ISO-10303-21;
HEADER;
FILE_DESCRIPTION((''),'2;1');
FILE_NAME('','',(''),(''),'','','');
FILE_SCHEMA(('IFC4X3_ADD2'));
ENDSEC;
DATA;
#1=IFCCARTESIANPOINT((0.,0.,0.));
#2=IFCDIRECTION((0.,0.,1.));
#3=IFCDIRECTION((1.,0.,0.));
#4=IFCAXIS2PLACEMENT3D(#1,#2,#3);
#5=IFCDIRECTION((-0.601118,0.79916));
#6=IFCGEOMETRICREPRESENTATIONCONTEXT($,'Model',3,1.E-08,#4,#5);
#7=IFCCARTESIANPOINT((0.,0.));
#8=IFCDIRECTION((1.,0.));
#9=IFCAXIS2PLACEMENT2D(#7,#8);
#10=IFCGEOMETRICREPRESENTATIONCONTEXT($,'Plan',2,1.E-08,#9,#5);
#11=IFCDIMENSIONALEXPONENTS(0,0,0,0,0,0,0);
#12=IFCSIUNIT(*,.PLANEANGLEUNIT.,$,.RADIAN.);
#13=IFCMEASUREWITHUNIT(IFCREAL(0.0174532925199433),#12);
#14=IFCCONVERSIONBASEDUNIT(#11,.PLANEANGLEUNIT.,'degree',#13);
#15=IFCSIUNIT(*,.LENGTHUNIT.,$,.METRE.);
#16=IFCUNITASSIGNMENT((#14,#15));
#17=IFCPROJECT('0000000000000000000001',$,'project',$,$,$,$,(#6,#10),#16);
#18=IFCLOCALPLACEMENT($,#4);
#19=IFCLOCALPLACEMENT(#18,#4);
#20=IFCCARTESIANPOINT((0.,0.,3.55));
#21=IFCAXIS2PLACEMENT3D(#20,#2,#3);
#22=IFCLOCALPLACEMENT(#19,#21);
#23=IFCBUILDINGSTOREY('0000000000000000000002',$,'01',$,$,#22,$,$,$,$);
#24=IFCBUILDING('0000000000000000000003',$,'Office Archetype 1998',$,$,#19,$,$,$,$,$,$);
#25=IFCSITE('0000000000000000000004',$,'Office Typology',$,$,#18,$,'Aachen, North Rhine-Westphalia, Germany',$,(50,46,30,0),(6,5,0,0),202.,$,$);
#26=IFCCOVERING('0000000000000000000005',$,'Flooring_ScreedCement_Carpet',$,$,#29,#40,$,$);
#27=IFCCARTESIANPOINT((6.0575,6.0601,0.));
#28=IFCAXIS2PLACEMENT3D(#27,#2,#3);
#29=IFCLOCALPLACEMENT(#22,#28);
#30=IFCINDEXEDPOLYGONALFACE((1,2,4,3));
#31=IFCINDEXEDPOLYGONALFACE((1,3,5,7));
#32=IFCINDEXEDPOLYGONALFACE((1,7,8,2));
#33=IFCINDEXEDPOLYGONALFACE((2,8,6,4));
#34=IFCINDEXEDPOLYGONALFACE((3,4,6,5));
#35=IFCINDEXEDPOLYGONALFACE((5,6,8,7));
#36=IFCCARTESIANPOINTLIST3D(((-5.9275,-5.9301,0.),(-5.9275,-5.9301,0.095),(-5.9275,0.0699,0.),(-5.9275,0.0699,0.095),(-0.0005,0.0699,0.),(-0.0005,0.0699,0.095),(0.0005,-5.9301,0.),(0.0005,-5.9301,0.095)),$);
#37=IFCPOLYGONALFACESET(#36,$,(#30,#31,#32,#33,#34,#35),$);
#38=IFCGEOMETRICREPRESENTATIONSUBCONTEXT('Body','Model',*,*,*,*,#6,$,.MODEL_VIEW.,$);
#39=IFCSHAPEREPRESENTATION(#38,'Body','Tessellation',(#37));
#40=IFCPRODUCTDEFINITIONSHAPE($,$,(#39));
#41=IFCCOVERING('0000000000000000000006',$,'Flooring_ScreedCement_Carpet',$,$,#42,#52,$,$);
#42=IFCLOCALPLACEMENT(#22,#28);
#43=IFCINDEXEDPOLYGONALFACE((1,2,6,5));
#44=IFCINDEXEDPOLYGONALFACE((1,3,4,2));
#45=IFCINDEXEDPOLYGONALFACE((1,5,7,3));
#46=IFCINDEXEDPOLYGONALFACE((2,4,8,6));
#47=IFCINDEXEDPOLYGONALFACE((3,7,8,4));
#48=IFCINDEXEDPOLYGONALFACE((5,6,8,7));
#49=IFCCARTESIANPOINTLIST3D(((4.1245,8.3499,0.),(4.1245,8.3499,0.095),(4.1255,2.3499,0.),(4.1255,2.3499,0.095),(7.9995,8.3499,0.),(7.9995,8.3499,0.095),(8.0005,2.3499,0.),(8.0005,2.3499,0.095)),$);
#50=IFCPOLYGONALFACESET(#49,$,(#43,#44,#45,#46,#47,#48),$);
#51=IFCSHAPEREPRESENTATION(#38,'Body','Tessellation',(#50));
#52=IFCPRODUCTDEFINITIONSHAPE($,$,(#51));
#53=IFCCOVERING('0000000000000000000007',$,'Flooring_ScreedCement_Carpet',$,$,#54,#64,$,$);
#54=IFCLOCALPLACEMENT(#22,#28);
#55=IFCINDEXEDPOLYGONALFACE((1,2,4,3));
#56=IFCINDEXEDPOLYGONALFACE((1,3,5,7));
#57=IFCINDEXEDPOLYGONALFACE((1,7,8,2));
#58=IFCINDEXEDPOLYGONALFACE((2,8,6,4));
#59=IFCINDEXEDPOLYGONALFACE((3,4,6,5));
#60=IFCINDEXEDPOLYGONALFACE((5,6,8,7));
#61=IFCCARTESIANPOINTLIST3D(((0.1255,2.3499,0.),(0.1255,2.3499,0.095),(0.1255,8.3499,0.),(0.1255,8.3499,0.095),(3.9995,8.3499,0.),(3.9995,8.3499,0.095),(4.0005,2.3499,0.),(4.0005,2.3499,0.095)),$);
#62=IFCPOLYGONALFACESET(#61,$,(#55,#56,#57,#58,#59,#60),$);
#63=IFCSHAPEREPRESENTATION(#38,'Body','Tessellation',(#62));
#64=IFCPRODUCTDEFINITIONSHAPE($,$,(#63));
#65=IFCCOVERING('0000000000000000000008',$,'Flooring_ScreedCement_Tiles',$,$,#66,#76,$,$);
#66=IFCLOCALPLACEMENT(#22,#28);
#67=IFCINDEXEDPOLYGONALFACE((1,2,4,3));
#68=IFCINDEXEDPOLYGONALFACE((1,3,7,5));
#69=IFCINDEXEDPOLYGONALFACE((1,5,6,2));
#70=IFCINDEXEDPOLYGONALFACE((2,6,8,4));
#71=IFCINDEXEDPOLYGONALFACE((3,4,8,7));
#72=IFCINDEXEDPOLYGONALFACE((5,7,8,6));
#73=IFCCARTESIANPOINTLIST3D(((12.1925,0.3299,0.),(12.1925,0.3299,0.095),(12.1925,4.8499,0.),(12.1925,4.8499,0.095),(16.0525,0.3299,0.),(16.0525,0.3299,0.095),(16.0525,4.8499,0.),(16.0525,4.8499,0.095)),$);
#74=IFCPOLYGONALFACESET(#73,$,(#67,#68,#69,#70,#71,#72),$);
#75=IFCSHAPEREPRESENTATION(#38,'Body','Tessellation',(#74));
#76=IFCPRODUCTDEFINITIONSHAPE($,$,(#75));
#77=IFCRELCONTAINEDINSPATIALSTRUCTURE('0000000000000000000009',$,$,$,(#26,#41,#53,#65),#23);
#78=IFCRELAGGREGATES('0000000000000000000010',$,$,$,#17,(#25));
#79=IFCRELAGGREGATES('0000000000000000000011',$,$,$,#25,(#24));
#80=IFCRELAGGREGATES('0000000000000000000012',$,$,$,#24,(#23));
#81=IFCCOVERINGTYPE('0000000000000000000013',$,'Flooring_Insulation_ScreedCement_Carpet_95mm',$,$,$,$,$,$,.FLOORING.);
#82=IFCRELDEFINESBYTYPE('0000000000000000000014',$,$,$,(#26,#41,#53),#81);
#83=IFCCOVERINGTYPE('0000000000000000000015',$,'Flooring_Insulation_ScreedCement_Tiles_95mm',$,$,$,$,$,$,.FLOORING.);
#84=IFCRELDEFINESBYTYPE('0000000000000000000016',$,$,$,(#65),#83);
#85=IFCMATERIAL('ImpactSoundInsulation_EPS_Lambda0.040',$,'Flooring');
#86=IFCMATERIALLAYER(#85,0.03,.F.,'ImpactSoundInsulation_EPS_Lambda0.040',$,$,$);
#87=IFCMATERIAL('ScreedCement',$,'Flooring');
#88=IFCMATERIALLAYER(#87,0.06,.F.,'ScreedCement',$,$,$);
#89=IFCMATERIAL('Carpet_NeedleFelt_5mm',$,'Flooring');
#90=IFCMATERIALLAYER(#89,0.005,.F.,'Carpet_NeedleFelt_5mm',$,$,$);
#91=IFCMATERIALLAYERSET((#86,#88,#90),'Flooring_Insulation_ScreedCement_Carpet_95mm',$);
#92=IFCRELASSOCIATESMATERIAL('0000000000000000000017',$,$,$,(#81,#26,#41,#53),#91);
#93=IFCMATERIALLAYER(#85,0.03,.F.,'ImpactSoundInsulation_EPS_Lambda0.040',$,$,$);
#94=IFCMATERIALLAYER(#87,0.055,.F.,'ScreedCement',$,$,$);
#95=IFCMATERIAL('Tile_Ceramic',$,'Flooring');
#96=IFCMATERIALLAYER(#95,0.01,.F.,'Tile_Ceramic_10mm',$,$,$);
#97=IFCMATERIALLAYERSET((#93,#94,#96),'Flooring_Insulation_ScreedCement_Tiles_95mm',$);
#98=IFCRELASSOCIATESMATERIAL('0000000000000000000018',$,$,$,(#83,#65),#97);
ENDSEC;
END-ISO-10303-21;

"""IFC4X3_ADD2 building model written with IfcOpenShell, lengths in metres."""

from ifc_helpers import new_model, entity, si_unit, converted_unit, direction, frame, origin_with_axes, origin_2d_with_axis, place, context, subcontext, project, spatial, line, indexed_curve, outline, extrude, material, layer, layer_set, layer_usage, type_object, element, save


model = new_model("IFC4X3_ADD2")

# Units and contexts
model_context = context("Model", 3, precision=1e-08, world=origin_with_axes(), true_north=direction((-0.601118, 0.79916)))
plan_context = context("Plan", 2, precision=1e-08, world=origin_2d_with_axis(), true_north=direction((-0.601118, 0.79916)))
body_context = subcontext(model_context, "Body", "Model", "MODEL_VIEW")
ifc_project = project(units=[converted_unit("PLANEANGLEUNIT", "degree", entity("IfcReal", 0.0174532925199433), si_unit("PLANEANGLEUNIT", "RADIAN"), dimensions=[0, 0, 0, 0, 0, 0, 0]), si_unit("LENGTHUNIT", "METRE")], contexts=[model_context, plan_context])

# Site, building, storey
site_placement = place(None, origin_with_axes())
site = spatial("IfcSite", under=ifc_project, at=site_placement, Name="Office Typology", LongName="Aachen, North Rhine-Westphalia, Germany", RefLatitude=(50, 46, 30, 0), RefLongitude=(6, 5, 0, 0), RefElevation=202.0)
building_placement = place(site_placement, origin_with_axes())
building = spatial("IfcBuilding", under=site, at=building_placement, Name="Office Archetype 1998")
storey_placement = place(building_placement, frame((0.0, 0.0, 3.55), z_axis=(0.0, 0.0, 1.0), x_axis=(1.0, 0.0, 0.0)))
storey = spatial("IfcBuildingStorey", under=building, at=storey_placement, Name="01")

# Coverings
ifc_material_1 = material(Name="ImpactSoundInsulation_EPS_Lambda0.040", Category="Flooring")
ifc_layer_1 = layer(ifc_material_1, 0.03, ventilated=False, Name="ImpactSoundInsulation_EPS_Lambda0.040")
ifc_material_2 = material(Name="ScreedCement", Category="Flooring")
ifc_layer_2 = layer(ifc_material_2, 0.06, ventilated=False, Name="ScreedCement")
ifc_material_3 = material(Name="Carpet_NeedleFelt_5mm", Category="Flooring")
ifc_layer_3 = layer(ifc_material_3, 0.005, ventilated=False, Name="Carpet_NeedleFelt_5mm")
ifc_layer_set_1 = layer_set([ifc_layer_1, ifc_layer_2, ifc_layer_3], Name="Flooring_Insulation_ScreedCement_Carpet_95mm")
ifc_layer_usage_1 = layer_usage(ifc_layer_set_1, "AXIS3", "POSITIVE", 0.0)
covering_type_1 = type_object("IfcCoveringType", Name="Flooring_Insulation_ScreedCement_Carpet_95mm", PredefinedType="FLOORING", material=ifc_layer_set_1)
covering_1_placement = place(storey_placement, frame((6.0575, 6.0601, 0.0), z_axis=(0.0, 0.0, 1.0), x_axis=(1.0, 0.0, 0.0)))
element("IfcCovering", 1, at=covering_1_placement, inside=storey, type_object=covering_type_1, material=ifc_layer_usage_1, Name="Flooring_ScreedCement_Carpet", context=body_context, shape_type="SweptSolid", body=[
    extrude(outline(indexed_curve([(-5.9275, -5.9301), (-5.9275, 0.0699), (-0.0005, 0.0699), (0.0005, -5.9301)], segments=[line(1, 2, 3, 4, 1)])), origin_with_axes(), (0.0, 0.0, 1.0), 0.095),
])
ifc_layer_usage_2 = layer_usage(ifc_layer_set_1, "AXIS3", "POSITIVE", 0.0)
covering_2_placement = place(storey_placement, frame((6.0575, 6.0601, 0.0), z_axis=(0.0, 0.0, 1.0), x_axis=(1.0, 0.0, 0.0)))
element("IfcCovering", 2, at=covering_2_placement, inside=storey, type_object=covering_type_1, material=ifc_layer_usage_2, Name="Flooring_ScreedCement_Carpet", context=body_context, shape_type="SweptSolid", body=[
    extrude(outline(indexed_curve([(4.1255, 2.3499), (4.1245, 8.3499), (7.9995, 8.3499), (8.0005, 2.3499)], segments=[line(1, 2, 3, 4, 1)])), origin_with_axes(), (0.0, 0.0, 1.0), 0.095),
])
ifc_layer_usage_3 = layer_usage(ifc_layer_set_1, "AXIS3", "POSITIVE", 0.0)
covering_3_placement = place(storey_placement, frame((6.0575, 6.0601, 0.0), z_axis=(0.0, 0.0, 1.0), x_axis=(1.0, 0.0, 0.0)))
element("IfcCovering", 3, at=covering_3_placement, inside=storey, type_object=covering_type_1, material=ifc_layer_usage_3, Name="Flooring_ScreedCement_Carpet", context=body_context, shape_type="SweptSolid", body=[
    extrude(outline(indexed_curve([(0.1255, 2.3499), (0.1255, 8.3499), (3.9995, 8.3499), (4.0005, 2.3499)], segments=[line(1, 2, 3, 4, 1)])), origin_with_axes(), (0.0, 0.0, 1.0), 0.095),
])
ifc_layer_4 = layer(ifc_material_1, 0.03, ventilated=False, Name="ImpactSoundInsulation_EPS_Lambda0.040")
ifc_layer_5 = layer(ifc_material_2, 0.055, ventilated=False, Name="ScreedCement")
ifc_material_4 = material(Name="Tile_Ceramic", Category="Flooring")
ifc_layer_6 = layer(ifc_material_4, 0.01, ventilated=False, Name="Tile_Ceramic_10mm")
ifc_layer_set_2 = layer_set([ifc_layer_4, ifc_layer_5, ifc_layer_6], Name="Flooring_Insulation_ScreedCement_Tiles_95mm")
ifc_layer_usage_4 = layer_usage(ifc_layer_set_2, "AXIS3", "POSITIVE", 0.0)
covering_type_2 = type_object("IfcCoveringType", Name="Flooring_Insulation_ScreedCement_Tiles_95mm", PredefinedType="FLOORING", material=ifc_layer_set_2)
covering_4_placement = place(storey_placement, frame((6.0575, 6.0601, 0.0), z_axis=(0.0, 0.0, 1.0), x_axis=(1.0, 0.0, 0.0)))
element("IfcCovering", 4, at=covering_4_placement, inside=storey, type_object=covering_type_2, material=ifc_layer_usage_4, Name="Flooring_ScreedCement_Tiles", context=body_context, shape_type="SweptSolid", body=[
    extrude(outline(indexed_curve([(12.1925, 0.3299), (12.1925, 4.8499), (16.0525, 4.8499), (16.0525, 0.3299)], segments=[line(1, 2, 3, 4, 1)])), origin_with_axes(), (0.0, 0.0, 1.0), 0.095),
])

save(model, "model.ifc")
